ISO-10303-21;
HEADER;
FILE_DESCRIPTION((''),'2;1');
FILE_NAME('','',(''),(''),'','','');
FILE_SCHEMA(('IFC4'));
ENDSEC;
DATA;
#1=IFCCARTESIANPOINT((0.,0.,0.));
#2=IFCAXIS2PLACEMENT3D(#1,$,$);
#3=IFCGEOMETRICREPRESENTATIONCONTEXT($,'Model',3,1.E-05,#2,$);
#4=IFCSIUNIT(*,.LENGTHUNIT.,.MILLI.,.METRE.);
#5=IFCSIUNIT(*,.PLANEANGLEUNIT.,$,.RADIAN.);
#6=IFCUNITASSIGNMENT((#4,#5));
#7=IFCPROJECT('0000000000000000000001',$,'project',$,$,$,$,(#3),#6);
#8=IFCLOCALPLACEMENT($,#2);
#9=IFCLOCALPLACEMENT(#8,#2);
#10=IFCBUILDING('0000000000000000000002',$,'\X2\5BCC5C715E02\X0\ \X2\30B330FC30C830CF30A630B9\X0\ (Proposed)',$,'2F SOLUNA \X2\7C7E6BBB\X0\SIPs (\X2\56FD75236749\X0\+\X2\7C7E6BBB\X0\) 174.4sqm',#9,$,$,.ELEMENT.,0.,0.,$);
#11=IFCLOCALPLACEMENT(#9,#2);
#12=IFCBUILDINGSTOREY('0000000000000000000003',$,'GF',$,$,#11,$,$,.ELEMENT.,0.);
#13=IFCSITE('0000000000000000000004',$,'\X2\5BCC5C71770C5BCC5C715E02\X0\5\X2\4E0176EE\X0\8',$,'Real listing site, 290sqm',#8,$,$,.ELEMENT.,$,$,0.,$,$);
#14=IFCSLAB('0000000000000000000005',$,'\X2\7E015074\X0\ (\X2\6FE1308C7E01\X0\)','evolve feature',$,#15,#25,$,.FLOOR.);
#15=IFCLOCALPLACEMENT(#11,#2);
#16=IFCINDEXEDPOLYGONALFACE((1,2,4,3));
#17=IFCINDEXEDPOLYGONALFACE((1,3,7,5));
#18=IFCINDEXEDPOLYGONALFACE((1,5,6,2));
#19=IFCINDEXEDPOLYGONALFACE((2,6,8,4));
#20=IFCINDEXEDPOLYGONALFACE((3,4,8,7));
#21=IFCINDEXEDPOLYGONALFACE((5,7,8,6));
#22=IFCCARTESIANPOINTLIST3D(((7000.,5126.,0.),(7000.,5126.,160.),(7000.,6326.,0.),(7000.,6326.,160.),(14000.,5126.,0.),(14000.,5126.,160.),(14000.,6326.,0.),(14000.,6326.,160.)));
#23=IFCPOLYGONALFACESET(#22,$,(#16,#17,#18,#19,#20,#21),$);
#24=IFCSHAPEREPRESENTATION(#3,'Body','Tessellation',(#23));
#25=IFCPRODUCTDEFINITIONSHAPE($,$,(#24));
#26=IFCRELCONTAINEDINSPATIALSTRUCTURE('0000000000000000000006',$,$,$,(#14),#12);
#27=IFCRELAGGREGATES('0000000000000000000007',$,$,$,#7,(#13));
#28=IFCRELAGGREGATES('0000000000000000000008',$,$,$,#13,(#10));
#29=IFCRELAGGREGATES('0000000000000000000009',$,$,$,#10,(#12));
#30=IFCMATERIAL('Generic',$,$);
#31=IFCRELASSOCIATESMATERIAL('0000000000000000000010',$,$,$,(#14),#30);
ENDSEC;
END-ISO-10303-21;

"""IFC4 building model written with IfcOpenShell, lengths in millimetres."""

from ifc_helpers import new_model, si_unit, frame, frame_2d, origin, place, context, project, spatial, rectangle, extrude, material, element, save


model = new_model("IFC4")

# Units and contexts
model_context = context("Model", 3, precision=1e-05, world=origin())
ifc_project = project(units=[si_unit("LENGTHUNIT", "METRE", prefix="MILLI"), si_unit("PLANEANGLEUNIT", "RADIAN")], contexts=[model_context])

# Site, building, storey
site_placement = place(None, origin())
site = spatial("IfcSite", under=ifc_project, at=site_placement, Name="富山県富山市5丁目8", ObjectType="Real listing site, 290sqm", CompositionType="ELEMENT", RefElevation=0.0)
building_placement = place(site_placement, origin())
building = spatial("IfcBuilding", under=site, at=building_placement, Name="富山市 コートハウス (Proposed)", ObjectType="2F SOLUNA 籾殻SIPs (国産杉+籾殻) 174.4sqm", CompositionType="ELEMENT", ElevationOfRefHeight=0.0, ElevationOfTerrain=0.0)
storey_placement = place(building_placement, origin())
storey = spatial("IfcBuildingStorey", under=building, at=storey_placement, Name="GF", CompositionType="ELEMENT", Elevation=0.0)

# Slab
ifc_material_1 = material(Name="Generic")
slab_1_placement = place(storey_placement, frame((3500.0, 2563.0, 0.0)))
element("IfcSlab", 1, at=slab_1_placement, inside=storey, material=ifc_material_1, Name="縁側 (濡れ縁)", Description="evolve feature", PredefinedType="FLOOR", context=model_context, shape_type="SweptSolid", body=[
    extrude(rectangle(XDim=7000.0, YDim=1200.0, at=frame_2d((3500.0, 600.0))), frame((3500.0, 2563.0, 0.0)), (0.0, 0.0, 1.0), 160.0),
])

save(model, "model.ifc")
